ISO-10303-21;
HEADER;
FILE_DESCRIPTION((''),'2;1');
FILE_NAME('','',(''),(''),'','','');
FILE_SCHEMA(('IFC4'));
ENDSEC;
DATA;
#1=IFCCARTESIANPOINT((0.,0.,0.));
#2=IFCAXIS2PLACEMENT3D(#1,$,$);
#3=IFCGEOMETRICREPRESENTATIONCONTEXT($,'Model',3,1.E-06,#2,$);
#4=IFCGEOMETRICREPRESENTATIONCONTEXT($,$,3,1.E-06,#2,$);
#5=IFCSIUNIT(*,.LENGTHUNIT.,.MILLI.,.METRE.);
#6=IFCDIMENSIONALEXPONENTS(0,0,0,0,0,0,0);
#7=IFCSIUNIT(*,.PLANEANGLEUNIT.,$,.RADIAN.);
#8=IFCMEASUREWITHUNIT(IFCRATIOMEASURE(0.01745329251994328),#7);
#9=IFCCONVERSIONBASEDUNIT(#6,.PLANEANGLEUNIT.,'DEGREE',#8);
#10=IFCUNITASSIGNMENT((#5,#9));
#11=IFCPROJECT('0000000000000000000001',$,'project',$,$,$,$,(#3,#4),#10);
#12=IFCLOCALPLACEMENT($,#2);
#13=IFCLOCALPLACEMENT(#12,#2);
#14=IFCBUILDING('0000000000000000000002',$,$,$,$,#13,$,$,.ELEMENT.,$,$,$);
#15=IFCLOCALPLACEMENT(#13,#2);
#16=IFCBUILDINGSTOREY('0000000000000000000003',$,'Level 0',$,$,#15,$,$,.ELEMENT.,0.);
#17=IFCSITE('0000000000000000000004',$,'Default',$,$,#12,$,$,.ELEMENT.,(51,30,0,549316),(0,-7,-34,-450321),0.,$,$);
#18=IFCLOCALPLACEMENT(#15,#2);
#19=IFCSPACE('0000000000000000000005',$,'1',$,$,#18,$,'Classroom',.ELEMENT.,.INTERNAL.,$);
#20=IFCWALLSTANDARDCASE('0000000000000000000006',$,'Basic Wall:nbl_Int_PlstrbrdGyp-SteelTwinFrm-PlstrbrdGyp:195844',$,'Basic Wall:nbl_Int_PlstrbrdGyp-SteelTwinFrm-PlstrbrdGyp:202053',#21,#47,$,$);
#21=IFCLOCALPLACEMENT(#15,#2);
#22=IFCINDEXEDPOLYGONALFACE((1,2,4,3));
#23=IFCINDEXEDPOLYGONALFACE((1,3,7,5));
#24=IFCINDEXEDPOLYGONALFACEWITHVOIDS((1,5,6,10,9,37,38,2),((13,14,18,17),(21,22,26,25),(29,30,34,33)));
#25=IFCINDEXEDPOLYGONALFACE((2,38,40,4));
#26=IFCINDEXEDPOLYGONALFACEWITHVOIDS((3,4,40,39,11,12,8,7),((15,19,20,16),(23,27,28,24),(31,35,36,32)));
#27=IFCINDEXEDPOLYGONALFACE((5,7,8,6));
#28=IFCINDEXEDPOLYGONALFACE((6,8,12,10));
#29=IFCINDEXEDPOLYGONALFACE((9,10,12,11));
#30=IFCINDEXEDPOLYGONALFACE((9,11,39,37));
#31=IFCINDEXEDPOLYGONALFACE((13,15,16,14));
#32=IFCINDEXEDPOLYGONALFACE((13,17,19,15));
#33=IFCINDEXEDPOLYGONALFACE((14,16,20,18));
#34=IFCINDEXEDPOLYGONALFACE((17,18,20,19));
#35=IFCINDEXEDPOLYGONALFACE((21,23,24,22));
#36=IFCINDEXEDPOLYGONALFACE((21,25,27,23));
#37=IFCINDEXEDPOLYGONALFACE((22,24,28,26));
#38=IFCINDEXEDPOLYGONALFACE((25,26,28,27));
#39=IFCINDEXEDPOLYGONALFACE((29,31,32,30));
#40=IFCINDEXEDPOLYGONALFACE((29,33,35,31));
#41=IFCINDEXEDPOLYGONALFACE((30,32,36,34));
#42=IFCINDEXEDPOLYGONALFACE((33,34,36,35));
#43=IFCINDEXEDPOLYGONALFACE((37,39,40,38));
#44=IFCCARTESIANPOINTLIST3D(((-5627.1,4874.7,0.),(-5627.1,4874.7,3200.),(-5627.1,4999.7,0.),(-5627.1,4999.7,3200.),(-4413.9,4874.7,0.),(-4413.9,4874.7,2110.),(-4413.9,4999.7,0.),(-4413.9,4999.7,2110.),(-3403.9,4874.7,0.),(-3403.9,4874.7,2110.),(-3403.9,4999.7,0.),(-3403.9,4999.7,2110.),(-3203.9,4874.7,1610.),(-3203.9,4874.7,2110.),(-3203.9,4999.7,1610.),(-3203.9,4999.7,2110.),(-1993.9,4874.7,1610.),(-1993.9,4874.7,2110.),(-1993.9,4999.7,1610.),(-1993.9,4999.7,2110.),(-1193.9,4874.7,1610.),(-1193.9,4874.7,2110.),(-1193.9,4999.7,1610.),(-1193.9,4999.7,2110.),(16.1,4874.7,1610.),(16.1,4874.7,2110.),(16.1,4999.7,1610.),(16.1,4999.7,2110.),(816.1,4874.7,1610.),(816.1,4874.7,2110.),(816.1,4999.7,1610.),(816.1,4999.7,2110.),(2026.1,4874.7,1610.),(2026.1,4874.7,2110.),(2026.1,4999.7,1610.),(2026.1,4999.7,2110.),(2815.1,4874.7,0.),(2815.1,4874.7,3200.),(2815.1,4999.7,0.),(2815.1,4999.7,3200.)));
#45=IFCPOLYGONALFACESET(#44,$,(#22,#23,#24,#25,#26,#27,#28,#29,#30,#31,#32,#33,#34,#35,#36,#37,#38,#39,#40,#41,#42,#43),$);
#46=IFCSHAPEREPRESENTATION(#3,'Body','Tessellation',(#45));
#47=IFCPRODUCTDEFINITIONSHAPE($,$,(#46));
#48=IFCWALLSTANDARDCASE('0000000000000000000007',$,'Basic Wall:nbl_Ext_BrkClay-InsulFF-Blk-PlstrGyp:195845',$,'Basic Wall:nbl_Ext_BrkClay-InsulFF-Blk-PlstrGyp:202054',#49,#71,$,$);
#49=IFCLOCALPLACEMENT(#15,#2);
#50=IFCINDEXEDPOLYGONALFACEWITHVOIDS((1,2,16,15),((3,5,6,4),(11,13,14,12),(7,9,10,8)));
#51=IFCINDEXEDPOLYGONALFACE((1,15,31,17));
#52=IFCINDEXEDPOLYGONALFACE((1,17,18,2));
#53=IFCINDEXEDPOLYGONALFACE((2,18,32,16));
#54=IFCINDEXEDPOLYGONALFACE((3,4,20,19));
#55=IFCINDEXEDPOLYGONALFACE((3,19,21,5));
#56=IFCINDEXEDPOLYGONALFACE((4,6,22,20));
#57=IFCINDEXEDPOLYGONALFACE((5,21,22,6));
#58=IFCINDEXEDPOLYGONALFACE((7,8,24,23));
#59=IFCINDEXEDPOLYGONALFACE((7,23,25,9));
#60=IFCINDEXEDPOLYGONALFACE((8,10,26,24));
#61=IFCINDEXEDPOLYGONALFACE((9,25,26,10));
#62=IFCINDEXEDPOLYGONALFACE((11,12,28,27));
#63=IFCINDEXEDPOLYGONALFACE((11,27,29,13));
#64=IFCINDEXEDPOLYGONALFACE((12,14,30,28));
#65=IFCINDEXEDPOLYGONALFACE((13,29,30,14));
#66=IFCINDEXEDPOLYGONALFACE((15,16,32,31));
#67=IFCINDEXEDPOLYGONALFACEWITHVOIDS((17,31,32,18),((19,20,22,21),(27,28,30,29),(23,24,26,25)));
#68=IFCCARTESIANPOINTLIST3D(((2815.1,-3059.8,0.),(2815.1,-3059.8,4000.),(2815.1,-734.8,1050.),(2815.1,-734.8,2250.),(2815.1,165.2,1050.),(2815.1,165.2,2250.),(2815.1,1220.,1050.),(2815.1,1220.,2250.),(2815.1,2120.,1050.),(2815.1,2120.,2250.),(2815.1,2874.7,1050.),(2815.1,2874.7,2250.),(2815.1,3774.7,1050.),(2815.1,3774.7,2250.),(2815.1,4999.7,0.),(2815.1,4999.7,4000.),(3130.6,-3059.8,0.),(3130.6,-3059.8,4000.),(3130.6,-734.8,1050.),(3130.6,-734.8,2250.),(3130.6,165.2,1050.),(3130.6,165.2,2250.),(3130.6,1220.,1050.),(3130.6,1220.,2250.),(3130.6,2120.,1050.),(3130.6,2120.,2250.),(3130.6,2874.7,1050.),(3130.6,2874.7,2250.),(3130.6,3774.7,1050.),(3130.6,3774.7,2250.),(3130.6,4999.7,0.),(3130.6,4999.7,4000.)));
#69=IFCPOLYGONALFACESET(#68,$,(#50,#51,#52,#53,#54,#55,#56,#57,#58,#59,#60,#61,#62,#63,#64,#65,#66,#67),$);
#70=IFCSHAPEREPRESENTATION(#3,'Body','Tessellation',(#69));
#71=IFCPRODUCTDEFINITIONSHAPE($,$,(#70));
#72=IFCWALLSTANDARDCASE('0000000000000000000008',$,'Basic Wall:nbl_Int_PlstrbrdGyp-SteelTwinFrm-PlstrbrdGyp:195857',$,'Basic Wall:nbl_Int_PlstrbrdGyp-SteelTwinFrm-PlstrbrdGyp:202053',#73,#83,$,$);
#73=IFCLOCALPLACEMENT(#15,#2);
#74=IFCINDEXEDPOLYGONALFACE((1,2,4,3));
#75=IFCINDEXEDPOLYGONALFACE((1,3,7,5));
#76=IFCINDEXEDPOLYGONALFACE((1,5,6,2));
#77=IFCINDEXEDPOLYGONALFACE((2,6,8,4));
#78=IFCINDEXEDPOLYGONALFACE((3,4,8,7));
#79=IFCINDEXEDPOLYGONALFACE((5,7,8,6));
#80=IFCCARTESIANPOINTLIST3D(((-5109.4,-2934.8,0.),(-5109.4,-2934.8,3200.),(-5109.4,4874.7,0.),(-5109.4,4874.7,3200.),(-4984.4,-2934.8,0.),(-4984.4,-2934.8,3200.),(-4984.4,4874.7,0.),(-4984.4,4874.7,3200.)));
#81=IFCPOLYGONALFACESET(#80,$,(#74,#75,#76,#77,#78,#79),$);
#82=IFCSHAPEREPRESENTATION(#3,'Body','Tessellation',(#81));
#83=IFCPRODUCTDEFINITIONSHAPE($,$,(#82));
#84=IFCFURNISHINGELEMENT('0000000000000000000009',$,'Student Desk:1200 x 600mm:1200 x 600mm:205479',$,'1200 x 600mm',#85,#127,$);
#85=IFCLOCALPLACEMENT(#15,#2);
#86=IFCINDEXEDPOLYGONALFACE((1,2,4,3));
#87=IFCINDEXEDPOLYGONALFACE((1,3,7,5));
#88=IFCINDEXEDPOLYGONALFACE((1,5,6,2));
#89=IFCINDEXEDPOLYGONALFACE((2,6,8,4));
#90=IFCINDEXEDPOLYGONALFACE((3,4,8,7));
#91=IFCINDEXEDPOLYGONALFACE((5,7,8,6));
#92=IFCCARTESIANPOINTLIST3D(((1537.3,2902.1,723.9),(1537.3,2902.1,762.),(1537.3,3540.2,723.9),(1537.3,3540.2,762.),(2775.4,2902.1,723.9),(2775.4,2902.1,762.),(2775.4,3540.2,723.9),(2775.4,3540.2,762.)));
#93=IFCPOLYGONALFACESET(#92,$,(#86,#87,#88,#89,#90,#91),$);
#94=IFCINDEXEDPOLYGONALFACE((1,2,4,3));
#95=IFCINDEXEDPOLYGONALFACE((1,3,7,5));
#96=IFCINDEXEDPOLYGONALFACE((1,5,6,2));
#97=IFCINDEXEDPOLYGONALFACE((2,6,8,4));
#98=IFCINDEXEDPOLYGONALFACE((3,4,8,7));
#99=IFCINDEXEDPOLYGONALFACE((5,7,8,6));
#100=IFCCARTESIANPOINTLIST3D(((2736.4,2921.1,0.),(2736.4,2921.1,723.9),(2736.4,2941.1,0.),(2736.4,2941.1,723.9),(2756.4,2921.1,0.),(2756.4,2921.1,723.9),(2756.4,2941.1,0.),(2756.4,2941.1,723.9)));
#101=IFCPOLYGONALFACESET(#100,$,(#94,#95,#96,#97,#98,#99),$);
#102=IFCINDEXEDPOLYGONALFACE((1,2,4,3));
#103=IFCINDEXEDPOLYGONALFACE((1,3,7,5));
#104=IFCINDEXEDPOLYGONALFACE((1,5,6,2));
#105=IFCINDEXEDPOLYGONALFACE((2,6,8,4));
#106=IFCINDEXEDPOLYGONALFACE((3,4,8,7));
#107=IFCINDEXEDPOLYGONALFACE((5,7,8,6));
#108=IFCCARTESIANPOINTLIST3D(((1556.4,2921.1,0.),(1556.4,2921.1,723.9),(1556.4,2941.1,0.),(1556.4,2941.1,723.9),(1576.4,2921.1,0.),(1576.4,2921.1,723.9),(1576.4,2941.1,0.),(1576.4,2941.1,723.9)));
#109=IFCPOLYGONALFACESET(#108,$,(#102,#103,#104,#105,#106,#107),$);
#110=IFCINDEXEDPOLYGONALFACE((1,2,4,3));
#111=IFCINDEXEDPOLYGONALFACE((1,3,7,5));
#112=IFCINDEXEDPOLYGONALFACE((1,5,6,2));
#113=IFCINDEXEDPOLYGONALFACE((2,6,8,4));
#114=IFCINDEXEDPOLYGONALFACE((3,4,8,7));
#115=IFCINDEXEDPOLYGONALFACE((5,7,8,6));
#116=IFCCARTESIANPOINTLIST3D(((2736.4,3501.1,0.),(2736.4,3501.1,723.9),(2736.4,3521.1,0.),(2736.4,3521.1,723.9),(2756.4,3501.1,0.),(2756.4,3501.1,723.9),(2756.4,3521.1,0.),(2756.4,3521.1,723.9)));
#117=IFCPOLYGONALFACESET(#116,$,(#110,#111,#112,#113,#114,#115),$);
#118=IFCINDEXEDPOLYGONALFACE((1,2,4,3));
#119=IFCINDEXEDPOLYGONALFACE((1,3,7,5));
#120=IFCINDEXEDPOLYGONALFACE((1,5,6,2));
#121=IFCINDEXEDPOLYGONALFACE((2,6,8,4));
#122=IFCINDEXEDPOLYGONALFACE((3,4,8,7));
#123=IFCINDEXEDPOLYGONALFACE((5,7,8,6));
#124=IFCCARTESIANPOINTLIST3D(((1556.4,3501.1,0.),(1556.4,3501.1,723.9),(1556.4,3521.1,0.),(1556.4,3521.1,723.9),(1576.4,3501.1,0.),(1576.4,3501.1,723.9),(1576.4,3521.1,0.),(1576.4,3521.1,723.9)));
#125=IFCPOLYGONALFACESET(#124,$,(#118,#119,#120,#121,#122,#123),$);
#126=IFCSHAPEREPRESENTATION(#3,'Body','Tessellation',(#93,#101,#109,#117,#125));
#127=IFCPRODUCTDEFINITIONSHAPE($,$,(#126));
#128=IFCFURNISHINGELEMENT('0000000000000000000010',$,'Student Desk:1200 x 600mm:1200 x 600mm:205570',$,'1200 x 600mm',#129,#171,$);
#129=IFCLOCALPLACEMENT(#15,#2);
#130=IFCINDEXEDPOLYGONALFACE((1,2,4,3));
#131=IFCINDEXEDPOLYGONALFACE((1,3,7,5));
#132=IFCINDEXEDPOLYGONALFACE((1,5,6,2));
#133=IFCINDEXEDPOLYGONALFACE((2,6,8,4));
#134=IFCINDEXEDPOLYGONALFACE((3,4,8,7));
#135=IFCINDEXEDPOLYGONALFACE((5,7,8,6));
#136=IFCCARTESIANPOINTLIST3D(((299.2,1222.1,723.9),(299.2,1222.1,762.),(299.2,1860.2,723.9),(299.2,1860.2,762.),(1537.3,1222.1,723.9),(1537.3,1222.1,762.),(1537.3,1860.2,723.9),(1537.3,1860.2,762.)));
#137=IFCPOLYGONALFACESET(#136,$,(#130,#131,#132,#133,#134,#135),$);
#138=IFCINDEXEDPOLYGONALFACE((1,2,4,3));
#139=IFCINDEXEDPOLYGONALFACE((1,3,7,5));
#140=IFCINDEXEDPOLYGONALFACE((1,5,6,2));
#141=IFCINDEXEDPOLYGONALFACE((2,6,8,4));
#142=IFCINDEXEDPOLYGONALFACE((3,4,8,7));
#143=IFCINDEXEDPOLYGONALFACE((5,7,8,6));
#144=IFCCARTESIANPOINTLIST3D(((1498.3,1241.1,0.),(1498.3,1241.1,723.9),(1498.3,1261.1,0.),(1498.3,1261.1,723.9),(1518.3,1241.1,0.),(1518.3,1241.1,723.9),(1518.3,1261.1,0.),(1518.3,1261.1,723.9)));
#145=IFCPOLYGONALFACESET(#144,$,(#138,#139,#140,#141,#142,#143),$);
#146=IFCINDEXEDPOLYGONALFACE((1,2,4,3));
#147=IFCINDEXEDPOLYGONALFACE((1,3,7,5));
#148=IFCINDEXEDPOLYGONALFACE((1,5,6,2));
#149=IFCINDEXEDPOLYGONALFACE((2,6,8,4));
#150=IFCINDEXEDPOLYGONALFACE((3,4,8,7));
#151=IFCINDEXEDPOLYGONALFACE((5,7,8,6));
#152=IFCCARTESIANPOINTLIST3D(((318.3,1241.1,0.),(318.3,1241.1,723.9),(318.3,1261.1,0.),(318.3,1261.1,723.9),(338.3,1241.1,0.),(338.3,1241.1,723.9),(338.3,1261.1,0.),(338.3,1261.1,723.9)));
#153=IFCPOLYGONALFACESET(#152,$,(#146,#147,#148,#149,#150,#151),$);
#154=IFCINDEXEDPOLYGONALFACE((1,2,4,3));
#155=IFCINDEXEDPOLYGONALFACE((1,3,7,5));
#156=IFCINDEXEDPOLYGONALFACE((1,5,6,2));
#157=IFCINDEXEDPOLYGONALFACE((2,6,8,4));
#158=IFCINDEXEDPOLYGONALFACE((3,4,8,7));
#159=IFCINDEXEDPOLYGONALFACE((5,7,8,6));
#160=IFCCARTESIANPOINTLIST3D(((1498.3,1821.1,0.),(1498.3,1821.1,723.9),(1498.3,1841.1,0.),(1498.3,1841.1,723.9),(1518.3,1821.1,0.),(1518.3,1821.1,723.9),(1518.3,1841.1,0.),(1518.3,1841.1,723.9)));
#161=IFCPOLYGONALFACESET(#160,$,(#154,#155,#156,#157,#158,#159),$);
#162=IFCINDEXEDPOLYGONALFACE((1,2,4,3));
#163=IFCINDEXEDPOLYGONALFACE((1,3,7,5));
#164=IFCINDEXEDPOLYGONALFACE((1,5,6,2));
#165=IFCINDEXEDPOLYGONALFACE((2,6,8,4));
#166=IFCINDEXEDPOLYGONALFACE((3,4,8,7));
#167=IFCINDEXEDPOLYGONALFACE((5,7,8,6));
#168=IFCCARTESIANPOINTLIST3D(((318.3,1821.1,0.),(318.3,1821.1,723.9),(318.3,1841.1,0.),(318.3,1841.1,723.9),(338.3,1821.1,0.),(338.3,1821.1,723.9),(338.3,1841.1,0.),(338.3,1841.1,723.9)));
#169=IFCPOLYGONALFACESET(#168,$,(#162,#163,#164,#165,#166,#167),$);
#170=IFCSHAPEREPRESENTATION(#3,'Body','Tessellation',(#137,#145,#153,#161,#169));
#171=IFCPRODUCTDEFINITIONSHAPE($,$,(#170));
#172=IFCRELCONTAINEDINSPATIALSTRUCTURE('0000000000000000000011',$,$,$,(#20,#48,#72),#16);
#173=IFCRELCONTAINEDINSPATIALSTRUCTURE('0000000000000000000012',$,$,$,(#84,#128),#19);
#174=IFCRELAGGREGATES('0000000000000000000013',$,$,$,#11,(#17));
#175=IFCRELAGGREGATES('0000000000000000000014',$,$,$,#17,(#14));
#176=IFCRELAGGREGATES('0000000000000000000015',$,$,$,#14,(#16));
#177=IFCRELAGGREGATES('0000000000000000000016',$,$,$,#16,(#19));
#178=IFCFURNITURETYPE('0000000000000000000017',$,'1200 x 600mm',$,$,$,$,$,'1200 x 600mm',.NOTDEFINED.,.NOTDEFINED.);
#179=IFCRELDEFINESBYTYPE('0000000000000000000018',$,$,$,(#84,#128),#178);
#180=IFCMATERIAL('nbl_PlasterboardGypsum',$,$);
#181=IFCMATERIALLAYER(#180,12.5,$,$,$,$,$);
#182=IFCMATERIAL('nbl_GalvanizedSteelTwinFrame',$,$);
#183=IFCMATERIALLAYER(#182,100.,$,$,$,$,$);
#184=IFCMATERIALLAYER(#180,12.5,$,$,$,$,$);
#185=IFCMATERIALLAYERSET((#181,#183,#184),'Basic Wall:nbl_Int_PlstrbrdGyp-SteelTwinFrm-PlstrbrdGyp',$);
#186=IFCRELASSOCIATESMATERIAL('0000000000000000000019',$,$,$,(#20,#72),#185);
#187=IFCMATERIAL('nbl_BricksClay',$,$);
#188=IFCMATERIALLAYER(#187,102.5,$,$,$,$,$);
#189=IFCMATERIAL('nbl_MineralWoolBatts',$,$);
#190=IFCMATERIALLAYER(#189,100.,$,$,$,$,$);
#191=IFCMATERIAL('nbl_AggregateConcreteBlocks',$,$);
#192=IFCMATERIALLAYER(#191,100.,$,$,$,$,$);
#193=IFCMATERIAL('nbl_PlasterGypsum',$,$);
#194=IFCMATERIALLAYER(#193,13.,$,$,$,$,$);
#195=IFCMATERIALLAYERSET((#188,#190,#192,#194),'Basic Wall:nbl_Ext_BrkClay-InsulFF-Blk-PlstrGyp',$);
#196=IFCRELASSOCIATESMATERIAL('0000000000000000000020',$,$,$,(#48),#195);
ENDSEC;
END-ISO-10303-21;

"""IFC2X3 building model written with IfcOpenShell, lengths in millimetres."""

from ifc_helpers import new_model, entity, si_unit, converted_unit, frame, frame_2d, origin, origin_2d_with_axis, place, context, project, spatial, rectangle, extrude, source, transform, mapped, material, layer, layer_set, layer_usage, type_object, type_shapes, element, save


model = new_model("IFC2X3")

# Units and contexts
model_context = context("Model", 3, precision=1e-06, world=origin())
context_of_model = context(None, 3, precision=1e-06, world=origin())
ifc_project = project(units=[si_unit("LENGTHUNIT", "METRE", prefix="MILLI"), converted_unit("PLANEANGLEUNIT", "DEGREE", entity("IfcRatioMeasure", 0.01745329251994328), si_unit("PLANEANGLEUNIT", "RADIAN"), dimensions=[0, 0, 0, 0, 0, 0, 0])], contexts=[model_context, context_of_model])

# Site, building, storey
site_placement = place(None, origin())
site = spatial("IfcSite", under=ifc_project, at=site_placement, Name="Default", CompositionType="ELEMENT", RefLatitude=(51, 30, 0, 549316), RefLongitude=(0, -7, -34, -450321), RefElevation=0.0)
building_placement = place(site_placement, origin())
building = spatial("IfcBuilding", under=site, at=building_placement, CompositionType="ELEMENT")
storey_placement = place(building_placement, origin())
storey = spatial("IfcBuildingStorey", under=building, at=storey_placement, Name="Level 0", CompositionType="ELEMENT", Elevation=0.0)

# Walls, openings
ifc_material_1 = material(Name="nbl_PlasterboardGypsum")
ifc_layer_1 = layer(ifc_material_1, 12.5)
ifc_material_2 = material(Name="nbl_GalvanizedSteelTwinFrame")
ifc_layer_2 = layer(ifc_material_2, 100.0)
ifc_layer_3 = layer(ifc_material_1, 12.5)
ifc_layer_set_1 = layer_set([ifc_layer_1, ifc_layer_2, ifc_layer_3], Name="Basic Wall:nbl_Int_PlstrbrdGyp-SteelTwinFrm-PlstrbrdGyp")
ifc_layer_usage_1 = layer_usage(ifc_layer_set_1, "AXIS2", "NEGATIVE", 62.5)
wall_1_placement = place(storey_placement, frame((-5627.1, 4937.2, 0.0)))
wall_1 = element("IfcWallStandardCase", 1, at=wall_1_placement, inside=storey, material=ifc_layer_usage_1, Name="Basic Wall:nbl_Int_PlstrbrdGyp-SteelTwinFrm-PlstrbrdGyp:195844", ObjectType="Basic Wall:nbl_Int_PlstrbrdGyp-SteelTwinFrm-PlstrbrdGyp:202053", context=model_context, shape_type="SweptSolid", body=[
    extrude(rectangle(XDim=8442.3, YDim=125.0, at=frame_2d((4221.1, 0.0), x_axis=(-1.0, 0.0))), origin(), (0.0, 0.0, 1.0), 3200.0),
])
opening_1_placement = place(wall_1_placement, frame((1213.3, -62.5, 0.0)))
element("IfcOpeningElement", 2, at=opening_1_placement, cuts=wall_1, ObjectType="Opening", context=model_context, shape_type="SweptSolid", body=[
    extrude(rectangle(XDim=2110.0, YDim=1010.0, at=frame_2d((1055.0, 505.0), x_axis=(1.0, 0.0))), frame((0.0, 0.0, 0.0), z_axis=(0.0, 1.0, 0.0), x_axis=(0.0, 0.0, 1.0)), (0.0, 0.0, 1.0), 125.0),
])
opening_2_placement = place(wall_1_placement, frame((7653.2, 62.5, 1610.0)))
element("IfcOpeningElement", 3, at=opening_2_placement, cuts=wall_1, ObjectType="Opening", context=model_context, shape_type="SweptSolid", body=[
    extrude(rectangle(XDim=500.0, YDim=1210.0, at=frame_2d((250.0, 605.0), x_axis=(-1.0, 0.0))), frame((0.0, 0.0, 0.0), z_axis=(0.0, -1.0, 0.0), x_axis=(0.0, 0.0, 1.0)), (0.0, 0.0, 1.0), 125.0),
])
opening_3_placement = place(wall_1_placement, frame((5643.3, 62.5, 1610.0)))
element("IfcOpeningElement", 4, at=opening_3_placement, cuts=wall_1, ObjectType="Opening", context=model_context, shape_type="SweptSolid", body=[
    extrude(rectangle(XDim=500.0, YDim=1210.0, at=frame_2d((250.0, 605.0), x_axis=(-1.0, 0.0))), frame((0.0, 0.0, 0.0), z_axis=(0.0, -1.0, 0.0), x_axis=(0.0, 0.0, 1.0)), (0.0, 0.0, 1.0), 125.0),
])
opening_4_placement = place(wall_1_placement, frame((3633.3, 62.5, 1610.0)))
element("IfcOpeningElement", 5, at=opening_4_placement, cuts=wall_1, ObjectType="Opening", context=model_context, shape_type="SweptSolid", body=[
    extrude(rectangle(XDim=500.0, YDim=1210.0, at=frame_2d((250.0, 605.0), x_axis=(-1.0, 0.0))), frame((0.0, 0.0, 0.0), z_axis=(0.0, -1.0, 0.0), x_axis=(0.0, 0.0, 1.0)), (0.0, 0.0, 1.0), 125.0),
])
ifc_material_3 = material(Name="nbl_BricksClay")
ifc_layer_4 = layer(ifc_material_3, 102.5)
ifc_material_4 = material(Name="nbl_MineralWoolBatts")
ifc_layer_5 = layer(ifc_material_4, 100.0)
ifc_material_5 = material(Name="nbl_AggregateConcreteBlocks")
ifc_layer_6 = layer(ifc_material_5, 100.0)
ifc_material_6 = material(Name="nbl_PlasterGypsum")
ifc_layer_7 = layer(ifc_material_6, 13.0)
ifc_layer_set_2 = layer_set([ifc_layer_4, ifc_layer_5, ifc_layer_6, ifc_layer_7], Name="Basic Wall:nbl_Ext_BrkClay-InsulFF-Blk-PlstrGyp")
ifc_layer_usage_2 = layer_usage(ifc_layer_set_2, "AXIS2", "NEGATIVE", 157.8)
wall_2_placement = place(storey_placement, frame((2972.9, 4999.7, 0.0), z_axis=(0.0, 0.0, 1.0), x_axis=(0.0, -1.0, 0.0)))
wall_2 = element("IfcWallStandardCase", 6, at=wall_2_placement, inside=storey, material=ifc_layer_usage_2, Name="Basic Wall:nbl_Ext_BrkClay-InsulFF-Blk-PlstrGyp:195845", ObjectType="Basic Wall:nbl_Ext_BrkClay-InsulFF-Blk-PlstrGyp:202054", context=model_context, shape_type="SweptSolid", body=[
    extrude(rectangle(XDim=8059.5, YDim=315.5, at=frame_2d((4029.8, 0.0), x_axis=(-1.0, 0.0))), origin(), (0.0, 0.0, 1.0), 4000.0),
])
opening_5_placement = place(wall_2_placement, frame((1225.0, -157.8, 1050.0)))
element("IfcOpeningElement", 7, at=opening_5_placement, cuts=wall_2, ObjectType="Opening", context=model_context, shape_type="SweptSolid", body=[
    extrude(rectangle(XDim=1200.0, YDim=900.0, at=frame_2d((600.0, 450.0), x_axis=(-1.0, 0.0))), frame((0.0, 0.0, 0.0), z_axis=(0.0, 1.0, 0.0), x_axis=(0.0, 0.0, 1.0)), (0.0, 0.0, 1.0), 315.5),
])
opening_6_placement = place(wall_2_placement, frame((4834.5, -157.8, 1050.0)))
element("IfcOpeningElement", 8, at=opening_6_placement, cuts=wall_2, ObjectType="Opening", context=model_context, shape_type="SweptSolid", body=[
    extrude(rectangle(XDim=1200.0, YDim=900.0, at=frame_2d((600.0, 450.0), x_axis=(-1.0, 0.0))), frame((0.0, 0.0, 0.0), z_axis=(0.0, 1.0, 0.0), x_axis=(0.0, 0.0, 1.0)), (0.0, 0.0, 1.0), 315.5),
])
opening_7_placement = place(wall_2_placement, frame((2879.8, -157.8, 1050.0)))
element("IfcOpeningElement", 9, at=opening_7_placement, cuts=wall_2, ObjectType="Opening", context=model_context, shape_type="SweptSolid", body=[
    extrude(rectangle(XDim=1200.0, YDim=900.0, at=frame_2d((600.0, 450.0), x_axis=(-1.0, 0.0))), frame((0.0, 0.0, 0.0), z_axis=(0.0, 1.0, 0.0), x_axis=(0.0, 0.0, 1.0)), (0.0, 0.0, 1.0), 315.5),
])

# Wall
ifc_layer_usage_3 = layer_usage(ifc_layer_set_1, "AXIS2", "NEGATIVE", 62.5)
wall_3_placement = place(storey_placement, frame((-5046.9, 4874.7, 0.0), z_axis=(0.0, 0.0, 1.0), x_axis=(0.0, -1.0, 0.0)))
element("IfcWallStandardCase", 10, at=wall_3_placement, inside=storey, material=ifc_layer_usage_3, Name="Basic Wall:nbl_Int_PlstrbrdGyp-SteelTwinFrm-PlstrbrdGyp:195857", ObjectType="Basic Wall:nbl_Int_PlstrbrdGyp-SteelTwinFrm-PlstrbrdGyp:202053", context=model_context, shape_type="SweptSolid", body=[
    extrude(rectangle(XDim=7809.5, YDim=125.0, at=frame_2d((3904.8, 0.0), x_axis=(-1.0, 0.0))), origin(), (0.0, 0.0, 1.0), 3200.0),
])

# Shared definitions
space_placement = place(storey_placement, origin())
space = spatial("IfcSpace", under=storey, at=space_placement, Name="1", LongName="Classroom", CompositionType="ELEMENT", InteriorOrExteriorSpace="INTERNAL")

# Furnishing elements
furniture_type = type_object("IfcFurnitureType", Name="1200 x 600mm", ElementType="1200 x 600mm", AssemblyPlace="NOTDEFINED")
shared_shape_1 = source(origin(), model_context, "Body", "SweptSolid", [
    extrude(rectangle(XDim=1238.1, YDim=638.1, at=origin_2d_with_axis()), frame((600.0, 300.0, 723.9), z_axis=(0.0, 0.0, 1.0), x_axis=(-1.0, 0.0, 0.0)), (0.0, 0.0, 1.0), 38.1),
    extrude(rectangle(XDim=20.0, YDim=20.0, at=origin_2d_with_axis()), frame((1190.0, 10.0, 0.0)), (0.0, 0.0, 1.0), 723.9),
    extrude(rectangle(XDim=20.0, YDim=20.0, at=origin_2d_with_axis()), frame((10.0, 10.0, 0.0), z_axis=(0.0, 0.0, 1.0), x_axis=(0.0, 1.0, 0.0)), (0.0, 0.0, 1.0), 723.9),
    extrude(rectangle(XDim=20.0, YDim=20.0, at=origin_2d_with_axis()), frame((1190.0, 590.0, 0.0), z_axis=(0.0, 0.0, 1.0), x_axis=(0.0, -1.0, 0.0)), (0.0, 0.0, 1.0), 723.9),
    extrude(rectangle(XDim=20.0, YDim=20.0, at=origin_2d_with_axis()), frame((10.0, 590.0, 0.0), z_axis=(0.0, 0.0, 1.0), x_axis=(-1.0, 0.0, 0.0)), (0.0, 0.0, 1.0), 723.9),
])
type_shapes(furniture_type, [shared_shape_1])
for number, where, name in (
    (11, (1556.4, 2921.1, 0.0), "Student Desk:1200 x 600mm:1200 x 600mm:205479"),
    (12, (318.3, 1241.1, 0.0), "Student Desk:1200 x 600mm:1200 x 600mm:205570"),
):
    element("IfcFurnishingElement", number, at=place(space_placement, frame(where)), inside=space, type_object=furniture_type, Name=name, ObjectType="1200 x 600mm", context=model_context, shape_type="MappedRepresentation", body=[
        mapped(shared_shape_1, transform((0.0, 0.0, 0.0), scale=1.0)),
    ])

save(model, "model.ifc")
